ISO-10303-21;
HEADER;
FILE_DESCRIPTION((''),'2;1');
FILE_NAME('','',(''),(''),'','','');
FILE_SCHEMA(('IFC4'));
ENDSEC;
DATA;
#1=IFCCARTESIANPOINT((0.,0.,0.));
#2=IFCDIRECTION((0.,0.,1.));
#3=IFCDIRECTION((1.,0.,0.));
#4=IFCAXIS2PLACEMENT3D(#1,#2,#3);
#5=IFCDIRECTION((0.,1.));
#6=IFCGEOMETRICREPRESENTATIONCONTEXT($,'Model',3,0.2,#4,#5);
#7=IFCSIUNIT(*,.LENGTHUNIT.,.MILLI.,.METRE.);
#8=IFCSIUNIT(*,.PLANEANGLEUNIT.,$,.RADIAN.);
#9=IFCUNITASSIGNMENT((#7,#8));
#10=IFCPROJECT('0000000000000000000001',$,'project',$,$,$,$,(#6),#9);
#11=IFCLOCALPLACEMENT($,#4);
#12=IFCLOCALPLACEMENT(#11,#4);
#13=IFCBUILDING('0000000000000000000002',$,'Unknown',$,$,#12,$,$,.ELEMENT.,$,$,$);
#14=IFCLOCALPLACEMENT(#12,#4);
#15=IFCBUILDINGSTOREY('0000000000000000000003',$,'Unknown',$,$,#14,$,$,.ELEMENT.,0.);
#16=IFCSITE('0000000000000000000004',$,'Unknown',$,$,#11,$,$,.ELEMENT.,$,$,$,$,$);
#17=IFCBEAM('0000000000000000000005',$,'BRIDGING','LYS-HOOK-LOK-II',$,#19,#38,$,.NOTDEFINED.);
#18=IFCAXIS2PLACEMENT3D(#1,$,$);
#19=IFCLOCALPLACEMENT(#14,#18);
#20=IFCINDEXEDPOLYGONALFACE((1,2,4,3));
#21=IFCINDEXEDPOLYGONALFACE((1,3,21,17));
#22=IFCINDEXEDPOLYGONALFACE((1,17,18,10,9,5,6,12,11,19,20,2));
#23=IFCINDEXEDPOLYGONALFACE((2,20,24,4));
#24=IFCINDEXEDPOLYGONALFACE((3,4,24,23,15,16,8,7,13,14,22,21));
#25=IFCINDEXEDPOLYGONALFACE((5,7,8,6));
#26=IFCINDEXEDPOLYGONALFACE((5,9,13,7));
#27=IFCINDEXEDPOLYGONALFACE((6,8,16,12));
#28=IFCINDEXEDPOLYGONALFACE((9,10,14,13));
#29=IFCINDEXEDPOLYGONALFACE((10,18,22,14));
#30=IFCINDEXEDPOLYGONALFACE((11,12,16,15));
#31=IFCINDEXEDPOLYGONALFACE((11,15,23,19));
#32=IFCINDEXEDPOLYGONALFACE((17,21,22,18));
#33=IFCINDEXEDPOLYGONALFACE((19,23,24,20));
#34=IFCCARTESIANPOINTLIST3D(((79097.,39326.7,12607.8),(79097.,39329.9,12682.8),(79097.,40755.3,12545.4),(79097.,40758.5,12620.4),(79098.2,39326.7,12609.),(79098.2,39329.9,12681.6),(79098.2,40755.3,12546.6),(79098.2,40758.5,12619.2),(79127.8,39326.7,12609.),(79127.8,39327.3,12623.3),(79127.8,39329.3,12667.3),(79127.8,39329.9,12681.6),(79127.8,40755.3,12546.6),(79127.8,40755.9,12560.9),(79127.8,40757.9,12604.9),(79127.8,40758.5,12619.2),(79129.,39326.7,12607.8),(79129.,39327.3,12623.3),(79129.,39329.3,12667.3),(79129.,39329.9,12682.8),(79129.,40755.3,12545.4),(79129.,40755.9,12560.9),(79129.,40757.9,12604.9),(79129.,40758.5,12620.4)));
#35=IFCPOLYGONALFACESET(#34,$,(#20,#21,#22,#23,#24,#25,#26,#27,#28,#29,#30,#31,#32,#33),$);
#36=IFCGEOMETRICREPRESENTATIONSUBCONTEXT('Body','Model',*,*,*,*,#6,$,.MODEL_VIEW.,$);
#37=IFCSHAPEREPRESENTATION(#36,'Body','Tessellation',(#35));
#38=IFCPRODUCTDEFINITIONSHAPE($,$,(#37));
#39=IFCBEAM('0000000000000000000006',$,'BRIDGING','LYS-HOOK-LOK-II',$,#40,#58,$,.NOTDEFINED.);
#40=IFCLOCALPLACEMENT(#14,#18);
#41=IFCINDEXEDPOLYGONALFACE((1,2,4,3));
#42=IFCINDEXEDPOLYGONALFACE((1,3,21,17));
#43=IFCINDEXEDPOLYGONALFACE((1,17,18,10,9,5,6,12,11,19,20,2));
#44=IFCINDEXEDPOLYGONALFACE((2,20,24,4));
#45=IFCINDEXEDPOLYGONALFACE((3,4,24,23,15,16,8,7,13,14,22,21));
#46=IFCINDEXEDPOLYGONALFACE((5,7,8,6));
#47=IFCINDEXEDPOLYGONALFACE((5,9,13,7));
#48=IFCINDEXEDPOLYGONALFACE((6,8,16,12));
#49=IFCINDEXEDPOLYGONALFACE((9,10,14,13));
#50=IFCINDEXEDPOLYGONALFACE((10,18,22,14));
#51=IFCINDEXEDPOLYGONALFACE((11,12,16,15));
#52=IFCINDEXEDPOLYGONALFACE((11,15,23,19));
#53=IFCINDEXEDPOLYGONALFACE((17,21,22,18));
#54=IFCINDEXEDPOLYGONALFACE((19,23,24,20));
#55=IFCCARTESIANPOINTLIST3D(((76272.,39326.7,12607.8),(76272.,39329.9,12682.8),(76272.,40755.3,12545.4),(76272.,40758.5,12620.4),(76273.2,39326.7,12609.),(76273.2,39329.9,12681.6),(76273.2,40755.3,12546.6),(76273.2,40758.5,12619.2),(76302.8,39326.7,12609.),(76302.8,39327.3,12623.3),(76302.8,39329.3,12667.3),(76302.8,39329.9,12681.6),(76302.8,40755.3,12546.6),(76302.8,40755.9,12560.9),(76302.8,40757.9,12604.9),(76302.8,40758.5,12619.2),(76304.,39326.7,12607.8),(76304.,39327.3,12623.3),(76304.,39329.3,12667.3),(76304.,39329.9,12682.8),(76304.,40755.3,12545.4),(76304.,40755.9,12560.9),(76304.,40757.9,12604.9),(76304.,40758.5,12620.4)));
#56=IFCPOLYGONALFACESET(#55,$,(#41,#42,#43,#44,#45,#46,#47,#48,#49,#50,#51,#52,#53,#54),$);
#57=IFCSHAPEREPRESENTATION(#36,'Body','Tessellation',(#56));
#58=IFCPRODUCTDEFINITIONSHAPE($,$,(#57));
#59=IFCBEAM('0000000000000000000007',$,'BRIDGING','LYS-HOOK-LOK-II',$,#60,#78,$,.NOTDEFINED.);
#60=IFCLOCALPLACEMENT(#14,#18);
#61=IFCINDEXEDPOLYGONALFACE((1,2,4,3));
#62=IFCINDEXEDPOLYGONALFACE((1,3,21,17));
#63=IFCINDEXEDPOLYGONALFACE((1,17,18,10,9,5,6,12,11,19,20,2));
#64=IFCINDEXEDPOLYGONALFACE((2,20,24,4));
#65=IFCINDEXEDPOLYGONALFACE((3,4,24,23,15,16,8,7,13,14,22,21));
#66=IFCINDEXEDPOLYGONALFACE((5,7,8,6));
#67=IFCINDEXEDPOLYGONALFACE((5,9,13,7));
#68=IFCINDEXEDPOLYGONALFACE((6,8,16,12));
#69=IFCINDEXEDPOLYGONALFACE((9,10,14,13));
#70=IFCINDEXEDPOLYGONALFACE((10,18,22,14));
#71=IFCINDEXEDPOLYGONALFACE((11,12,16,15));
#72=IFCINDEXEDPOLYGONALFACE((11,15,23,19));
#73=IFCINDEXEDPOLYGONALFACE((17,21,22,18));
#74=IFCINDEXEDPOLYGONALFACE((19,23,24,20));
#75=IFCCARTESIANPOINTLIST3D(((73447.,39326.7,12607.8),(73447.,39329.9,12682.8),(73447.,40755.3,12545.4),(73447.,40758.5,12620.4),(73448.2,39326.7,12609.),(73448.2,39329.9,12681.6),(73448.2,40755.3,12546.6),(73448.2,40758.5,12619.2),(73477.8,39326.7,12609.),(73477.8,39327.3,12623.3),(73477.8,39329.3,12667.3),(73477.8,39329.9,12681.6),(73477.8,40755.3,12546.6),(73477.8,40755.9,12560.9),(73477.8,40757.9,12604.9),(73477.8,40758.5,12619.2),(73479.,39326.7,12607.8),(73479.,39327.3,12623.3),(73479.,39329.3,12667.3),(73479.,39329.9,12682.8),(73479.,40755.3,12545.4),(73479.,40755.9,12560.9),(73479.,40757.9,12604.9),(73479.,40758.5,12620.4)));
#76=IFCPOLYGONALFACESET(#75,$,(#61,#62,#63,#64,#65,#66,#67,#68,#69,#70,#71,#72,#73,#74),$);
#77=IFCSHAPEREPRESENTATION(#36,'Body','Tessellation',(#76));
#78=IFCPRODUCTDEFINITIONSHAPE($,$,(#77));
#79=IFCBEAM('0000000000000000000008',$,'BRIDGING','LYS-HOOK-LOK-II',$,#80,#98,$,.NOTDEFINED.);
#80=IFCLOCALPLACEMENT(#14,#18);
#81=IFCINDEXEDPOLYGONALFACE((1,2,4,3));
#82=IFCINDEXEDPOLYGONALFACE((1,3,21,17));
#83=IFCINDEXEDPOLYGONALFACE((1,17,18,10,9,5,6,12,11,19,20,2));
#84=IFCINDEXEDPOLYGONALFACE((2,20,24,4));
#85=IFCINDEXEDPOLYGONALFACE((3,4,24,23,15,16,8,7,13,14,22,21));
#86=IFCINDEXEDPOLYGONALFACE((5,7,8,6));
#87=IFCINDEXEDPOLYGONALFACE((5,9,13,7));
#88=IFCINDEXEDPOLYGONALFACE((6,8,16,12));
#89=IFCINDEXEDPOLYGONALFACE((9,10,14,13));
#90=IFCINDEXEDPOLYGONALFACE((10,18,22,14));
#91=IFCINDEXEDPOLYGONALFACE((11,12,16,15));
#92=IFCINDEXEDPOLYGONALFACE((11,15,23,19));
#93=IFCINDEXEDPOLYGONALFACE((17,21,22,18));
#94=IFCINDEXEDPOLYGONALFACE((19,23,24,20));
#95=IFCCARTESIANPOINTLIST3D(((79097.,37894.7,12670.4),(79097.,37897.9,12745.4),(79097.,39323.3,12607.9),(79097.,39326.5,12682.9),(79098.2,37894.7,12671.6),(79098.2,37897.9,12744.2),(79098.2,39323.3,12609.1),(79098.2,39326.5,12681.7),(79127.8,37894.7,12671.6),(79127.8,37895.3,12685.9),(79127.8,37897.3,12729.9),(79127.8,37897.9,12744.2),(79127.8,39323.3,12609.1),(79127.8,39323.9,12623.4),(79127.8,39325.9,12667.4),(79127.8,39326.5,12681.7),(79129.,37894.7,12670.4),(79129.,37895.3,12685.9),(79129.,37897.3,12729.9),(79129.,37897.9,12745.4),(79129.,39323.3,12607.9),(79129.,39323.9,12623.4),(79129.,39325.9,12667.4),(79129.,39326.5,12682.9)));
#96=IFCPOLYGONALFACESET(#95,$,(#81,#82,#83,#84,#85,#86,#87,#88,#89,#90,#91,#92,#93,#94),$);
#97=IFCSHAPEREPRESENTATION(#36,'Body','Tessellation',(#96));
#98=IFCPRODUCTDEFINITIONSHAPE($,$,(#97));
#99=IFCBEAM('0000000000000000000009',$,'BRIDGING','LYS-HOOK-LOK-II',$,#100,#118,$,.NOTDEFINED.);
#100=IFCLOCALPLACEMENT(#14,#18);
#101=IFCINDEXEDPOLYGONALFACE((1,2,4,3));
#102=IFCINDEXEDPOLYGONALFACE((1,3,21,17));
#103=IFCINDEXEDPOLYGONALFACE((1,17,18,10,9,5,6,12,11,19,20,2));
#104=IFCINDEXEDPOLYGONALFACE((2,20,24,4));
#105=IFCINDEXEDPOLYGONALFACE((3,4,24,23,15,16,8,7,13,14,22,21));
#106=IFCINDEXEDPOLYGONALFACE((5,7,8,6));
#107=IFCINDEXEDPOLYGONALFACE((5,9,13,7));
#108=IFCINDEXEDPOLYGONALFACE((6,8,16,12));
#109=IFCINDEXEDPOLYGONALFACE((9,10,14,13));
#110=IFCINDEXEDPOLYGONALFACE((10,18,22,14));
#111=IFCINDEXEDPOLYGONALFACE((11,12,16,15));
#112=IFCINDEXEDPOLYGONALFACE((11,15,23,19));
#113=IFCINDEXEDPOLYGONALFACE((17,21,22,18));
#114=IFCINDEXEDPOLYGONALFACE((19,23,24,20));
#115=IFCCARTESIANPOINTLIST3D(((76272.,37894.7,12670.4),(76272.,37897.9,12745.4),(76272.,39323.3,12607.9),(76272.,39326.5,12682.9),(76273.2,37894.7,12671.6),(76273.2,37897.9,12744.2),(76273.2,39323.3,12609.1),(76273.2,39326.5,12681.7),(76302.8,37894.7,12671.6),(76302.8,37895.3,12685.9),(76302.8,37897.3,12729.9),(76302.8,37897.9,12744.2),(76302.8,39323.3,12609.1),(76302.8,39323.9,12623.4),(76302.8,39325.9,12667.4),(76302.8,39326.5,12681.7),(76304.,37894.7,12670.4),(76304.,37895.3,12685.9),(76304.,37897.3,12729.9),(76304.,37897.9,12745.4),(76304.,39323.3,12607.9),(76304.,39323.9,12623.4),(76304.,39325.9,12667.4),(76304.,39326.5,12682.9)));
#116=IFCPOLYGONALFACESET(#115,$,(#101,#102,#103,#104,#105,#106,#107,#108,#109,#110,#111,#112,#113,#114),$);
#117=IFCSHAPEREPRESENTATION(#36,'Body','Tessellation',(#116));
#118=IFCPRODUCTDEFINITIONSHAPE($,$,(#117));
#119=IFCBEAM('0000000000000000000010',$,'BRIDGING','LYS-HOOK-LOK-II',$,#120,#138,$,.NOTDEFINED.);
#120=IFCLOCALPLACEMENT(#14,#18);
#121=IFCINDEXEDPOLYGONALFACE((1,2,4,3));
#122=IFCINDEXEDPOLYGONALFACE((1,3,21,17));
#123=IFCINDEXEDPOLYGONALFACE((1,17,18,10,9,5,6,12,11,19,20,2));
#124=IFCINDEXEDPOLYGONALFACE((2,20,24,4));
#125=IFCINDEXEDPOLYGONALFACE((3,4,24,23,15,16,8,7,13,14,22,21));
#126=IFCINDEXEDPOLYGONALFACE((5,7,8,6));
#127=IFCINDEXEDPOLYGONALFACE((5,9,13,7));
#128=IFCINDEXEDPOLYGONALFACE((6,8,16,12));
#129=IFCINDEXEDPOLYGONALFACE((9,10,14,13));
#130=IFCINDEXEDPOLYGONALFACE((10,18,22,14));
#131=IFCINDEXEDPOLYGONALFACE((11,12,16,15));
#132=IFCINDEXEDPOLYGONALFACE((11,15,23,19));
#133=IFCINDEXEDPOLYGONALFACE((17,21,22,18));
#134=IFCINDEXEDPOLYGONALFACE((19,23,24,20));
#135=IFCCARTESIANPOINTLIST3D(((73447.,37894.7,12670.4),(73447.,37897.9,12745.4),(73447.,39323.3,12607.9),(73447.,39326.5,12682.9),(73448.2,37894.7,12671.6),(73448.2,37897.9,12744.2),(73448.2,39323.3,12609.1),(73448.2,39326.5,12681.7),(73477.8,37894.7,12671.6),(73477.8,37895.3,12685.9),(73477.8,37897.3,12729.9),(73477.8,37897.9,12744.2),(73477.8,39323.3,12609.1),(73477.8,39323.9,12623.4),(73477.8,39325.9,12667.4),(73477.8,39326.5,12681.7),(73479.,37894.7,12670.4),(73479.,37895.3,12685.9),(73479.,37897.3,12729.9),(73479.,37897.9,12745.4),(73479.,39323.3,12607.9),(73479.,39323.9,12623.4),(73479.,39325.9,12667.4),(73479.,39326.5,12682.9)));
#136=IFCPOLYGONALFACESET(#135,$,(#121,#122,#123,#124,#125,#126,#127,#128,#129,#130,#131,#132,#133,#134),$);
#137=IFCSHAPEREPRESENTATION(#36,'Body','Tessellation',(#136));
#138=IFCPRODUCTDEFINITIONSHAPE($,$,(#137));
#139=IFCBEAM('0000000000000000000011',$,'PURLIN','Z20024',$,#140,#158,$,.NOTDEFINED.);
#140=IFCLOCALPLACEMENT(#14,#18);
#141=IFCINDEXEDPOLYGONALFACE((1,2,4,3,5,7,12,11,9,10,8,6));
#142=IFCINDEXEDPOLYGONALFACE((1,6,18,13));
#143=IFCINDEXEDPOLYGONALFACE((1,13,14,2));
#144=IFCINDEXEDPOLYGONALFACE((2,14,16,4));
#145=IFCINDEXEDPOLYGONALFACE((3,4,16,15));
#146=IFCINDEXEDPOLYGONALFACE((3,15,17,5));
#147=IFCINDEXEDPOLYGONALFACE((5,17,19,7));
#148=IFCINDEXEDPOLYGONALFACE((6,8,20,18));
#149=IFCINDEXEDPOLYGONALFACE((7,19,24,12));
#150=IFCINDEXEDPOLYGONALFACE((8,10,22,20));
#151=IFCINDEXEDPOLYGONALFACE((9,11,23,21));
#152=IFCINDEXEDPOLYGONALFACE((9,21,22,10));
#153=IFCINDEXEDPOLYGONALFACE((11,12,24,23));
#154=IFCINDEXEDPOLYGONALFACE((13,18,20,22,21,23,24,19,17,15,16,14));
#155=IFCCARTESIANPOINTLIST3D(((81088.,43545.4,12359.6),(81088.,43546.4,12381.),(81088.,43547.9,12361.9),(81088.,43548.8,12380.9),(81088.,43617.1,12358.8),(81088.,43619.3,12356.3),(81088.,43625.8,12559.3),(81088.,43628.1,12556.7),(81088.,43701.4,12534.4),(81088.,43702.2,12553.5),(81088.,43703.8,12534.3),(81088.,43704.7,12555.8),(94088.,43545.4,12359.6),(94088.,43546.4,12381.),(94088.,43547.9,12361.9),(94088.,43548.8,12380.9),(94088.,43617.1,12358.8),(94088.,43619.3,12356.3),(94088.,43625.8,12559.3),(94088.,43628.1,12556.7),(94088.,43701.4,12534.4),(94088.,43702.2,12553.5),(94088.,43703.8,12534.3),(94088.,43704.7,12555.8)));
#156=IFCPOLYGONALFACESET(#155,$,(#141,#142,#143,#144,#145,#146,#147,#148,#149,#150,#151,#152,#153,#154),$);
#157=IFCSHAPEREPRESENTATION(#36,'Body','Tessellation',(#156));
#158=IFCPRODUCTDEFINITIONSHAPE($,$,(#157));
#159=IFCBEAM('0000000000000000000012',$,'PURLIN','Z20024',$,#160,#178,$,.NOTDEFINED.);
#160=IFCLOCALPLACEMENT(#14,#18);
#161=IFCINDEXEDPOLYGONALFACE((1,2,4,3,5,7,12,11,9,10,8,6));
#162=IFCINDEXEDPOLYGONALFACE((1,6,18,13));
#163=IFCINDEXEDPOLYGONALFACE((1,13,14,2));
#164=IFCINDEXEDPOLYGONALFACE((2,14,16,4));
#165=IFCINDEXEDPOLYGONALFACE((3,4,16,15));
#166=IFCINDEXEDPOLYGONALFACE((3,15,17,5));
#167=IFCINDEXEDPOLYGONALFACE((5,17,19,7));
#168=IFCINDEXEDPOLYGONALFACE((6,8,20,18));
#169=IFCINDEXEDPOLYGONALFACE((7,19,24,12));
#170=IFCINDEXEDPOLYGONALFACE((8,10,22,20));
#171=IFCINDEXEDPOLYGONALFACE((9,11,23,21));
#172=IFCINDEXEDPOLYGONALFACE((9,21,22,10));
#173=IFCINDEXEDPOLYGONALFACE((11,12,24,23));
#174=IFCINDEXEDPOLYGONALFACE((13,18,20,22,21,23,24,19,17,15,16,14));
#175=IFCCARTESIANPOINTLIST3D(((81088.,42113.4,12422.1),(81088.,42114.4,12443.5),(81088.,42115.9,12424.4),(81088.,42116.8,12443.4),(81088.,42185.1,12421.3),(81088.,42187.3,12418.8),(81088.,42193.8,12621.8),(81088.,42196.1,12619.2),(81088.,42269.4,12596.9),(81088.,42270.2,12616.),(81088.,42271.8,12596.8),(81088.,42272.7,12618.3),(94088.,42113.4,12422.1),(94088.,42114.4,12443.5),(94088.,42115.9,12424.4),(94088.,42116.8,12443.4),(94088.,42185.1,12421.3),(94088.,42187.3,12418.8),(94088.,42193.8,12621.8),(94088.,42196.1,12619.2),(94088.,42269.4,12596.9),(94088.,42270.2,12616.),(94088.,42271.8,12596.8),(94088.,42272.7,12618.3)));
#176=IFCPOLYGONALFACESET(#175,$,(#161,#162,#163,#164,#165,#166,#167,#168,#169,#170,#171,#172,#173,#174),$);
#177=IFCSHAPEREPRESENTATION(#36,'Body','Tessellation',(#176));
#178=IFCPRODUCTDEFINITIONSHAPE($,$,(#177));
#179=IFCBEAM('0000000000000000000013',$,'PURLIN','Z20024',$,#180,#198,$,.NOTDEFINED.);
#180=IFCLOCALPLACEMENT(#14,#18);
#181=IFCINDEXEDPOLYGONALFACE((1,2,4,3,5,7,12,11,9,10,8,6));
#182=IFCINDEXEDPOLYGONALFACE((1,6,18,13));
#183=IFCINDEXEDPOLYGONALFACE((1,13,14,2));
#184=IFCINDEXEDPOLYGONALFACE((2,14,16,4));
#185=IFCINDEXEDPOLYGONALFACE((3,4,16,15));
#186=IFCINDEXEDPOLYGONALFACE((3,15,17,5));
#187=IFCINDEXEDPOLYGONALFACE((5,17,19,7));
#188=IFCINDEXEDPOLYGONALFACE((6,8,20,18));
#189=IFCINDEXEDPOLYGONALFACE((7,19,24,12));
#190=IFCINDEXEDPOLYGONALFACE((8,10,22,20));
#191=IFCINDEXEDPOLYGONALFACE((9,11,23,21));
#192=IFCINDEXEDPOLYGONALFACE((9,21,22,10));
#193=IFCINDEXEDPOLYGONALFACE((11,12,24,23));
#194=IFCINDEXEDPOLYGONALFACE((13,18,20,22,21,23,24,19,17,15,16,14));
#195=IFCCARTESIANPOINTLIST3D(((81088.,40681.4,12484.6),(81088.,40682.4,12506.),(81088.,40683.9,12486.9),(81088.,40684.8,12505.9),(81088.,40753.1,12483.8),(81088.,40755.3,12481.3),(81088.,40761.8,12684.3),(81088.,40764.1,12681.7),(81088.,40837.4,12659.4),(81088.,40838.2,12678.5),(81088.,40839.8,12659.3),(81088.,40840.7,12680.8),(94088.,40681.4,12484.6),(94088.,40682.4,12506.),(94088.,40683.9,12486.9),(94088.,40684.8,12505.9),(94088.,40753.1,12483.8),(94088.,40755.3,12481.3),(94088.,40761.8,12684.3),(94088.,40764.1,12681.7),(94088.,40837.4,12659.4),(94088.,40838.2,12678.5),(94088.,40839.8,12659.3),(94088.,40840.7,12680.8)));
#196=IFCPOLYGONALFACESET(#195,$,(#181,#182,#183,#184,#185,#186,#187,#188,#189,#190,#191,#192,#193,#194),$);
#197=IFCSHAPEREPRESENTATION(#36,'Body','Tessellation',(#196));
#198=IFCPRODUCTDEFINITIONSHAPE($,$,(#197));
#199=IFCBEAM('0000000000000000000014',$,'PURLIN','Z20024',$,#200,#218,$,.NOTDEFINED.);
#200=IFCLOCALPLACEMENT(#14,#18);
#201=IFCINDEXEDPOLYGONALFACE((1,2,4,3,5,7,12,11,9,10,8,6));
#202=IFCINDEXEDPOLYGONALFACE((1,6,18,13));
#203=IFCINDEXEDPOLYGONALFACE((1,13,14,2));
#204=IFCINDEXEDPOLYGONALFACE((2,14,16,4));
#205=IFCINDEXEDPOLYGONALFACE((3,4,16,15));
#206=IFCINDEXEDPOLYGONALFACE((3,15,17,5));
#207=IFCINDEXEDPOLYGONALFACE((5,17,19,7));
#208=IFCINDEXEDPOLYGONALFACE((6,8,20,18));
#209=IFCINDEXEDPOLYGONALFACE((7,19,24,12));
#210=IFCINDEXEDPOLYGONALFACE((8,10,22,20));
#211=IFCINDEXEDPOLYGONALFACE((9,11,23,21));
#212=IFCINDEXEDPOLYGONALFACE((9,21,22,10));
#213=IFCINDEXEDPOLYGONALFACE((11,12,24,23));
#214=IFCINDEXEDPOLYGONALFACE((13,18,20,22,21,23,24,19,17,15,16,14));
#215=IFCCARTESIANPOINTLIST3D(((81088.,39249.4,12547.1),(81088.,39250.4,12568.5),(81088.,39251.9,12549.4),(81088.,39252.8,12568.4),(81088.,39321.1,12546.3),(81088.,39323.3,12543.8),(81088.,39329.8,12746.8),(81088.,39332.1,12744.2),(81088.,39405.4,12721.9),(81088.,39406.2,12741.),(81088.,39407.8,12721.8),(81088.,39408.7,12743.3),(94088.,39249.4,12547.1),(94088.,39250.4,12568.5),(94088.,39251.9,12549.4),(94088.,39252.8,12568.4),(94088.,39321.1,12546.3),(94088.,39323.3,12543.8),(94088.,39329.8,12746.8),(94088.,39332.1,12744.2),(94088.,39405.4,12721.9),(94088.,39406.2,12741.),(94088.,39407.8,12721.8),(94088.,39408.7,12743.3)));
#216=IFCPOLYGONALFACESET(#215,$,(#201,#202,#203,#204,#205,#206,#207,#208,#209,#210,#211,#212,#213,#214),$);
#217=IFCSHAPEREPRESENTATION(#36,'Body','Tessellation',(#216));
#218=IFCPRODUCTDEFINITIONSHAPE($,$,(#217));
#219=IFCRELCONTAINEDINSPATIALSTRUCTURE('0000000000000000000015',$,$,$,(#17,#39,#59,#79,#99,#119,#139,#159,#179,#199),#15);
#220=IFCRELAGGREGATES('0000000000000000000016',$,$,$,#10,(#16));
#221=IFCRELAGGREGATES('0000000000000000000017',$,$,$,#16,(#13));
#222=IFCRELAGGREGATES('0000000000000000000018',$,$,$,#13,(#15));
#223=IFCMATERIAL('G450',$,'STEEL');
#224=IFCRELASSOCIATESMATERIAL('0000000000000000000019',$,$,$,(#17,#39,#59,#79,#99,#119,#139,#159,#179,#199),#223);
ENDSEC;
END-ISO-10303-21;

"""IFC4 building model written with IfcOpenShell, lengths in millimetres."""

from ifc_helpers import new_model, si_unit, direction, frame, origin_with_axes, place, context, subcontext, project, spatial, line, indexed_curve, outline, extrude, material, element, save


model = new_model("IFC4")

# Units and contexts
model_context = context("Model", 3, precision=0.2, world=origin_with_axes(), true_north=direction((0.0, 1.0)))
body_context = subcontext(model_context, "Body", "Model", "MODEL_VIEW")
ifc_project = project(units=[si_unit("LENGTHUNIT", "METRE", prefix="MILLI"), si_unit("PLANEANGLEUNIT", "RADIAN")], contexts=[model_context])

# Site, building, storey
site_placement = place(None, origin_with_axes())
site = spatial("IfcSite", under=ifc_project, at=site_placement, Name="Unknown", CompositionType="ELEMENT")
building_placement = place(site_placement, origin_with_axes())
building = spatial("IfcBuilding", under=site, at=building_placement, Name="Unknown", CompositionType="ELEMENT")
storey_placement = place(building_placement, origin_with_axes())
storey = spatial("IfcBuildingStorey", under=building, at=storey_placement, Name="Unknown", CompositionType="ELEMENT", Elevation=0.0)

# Beams
ifc_material_1 = material(Name="G450", Category="STEEL")
for number, where, z_axis, x_axis, name in (
    (1, (79113.0, 39328.3, 12645.3), (1.0, 0.0, 0.0), (0.0, 0.999047, -0.043638), "BRIDGING"),
    (2, (76288.0, 39328.3, 12645.3), (1.0, 0.0, 0.0), (0.0, 0.999047, -0.043638), "BRIDGING"),
    (3, (73463.0, 39328.3, 12645.3), (1.0, 0.0, 0.0), (0.0, 0.999047, -0.043638), "BRIDGING"),
):
    element("IfcBeam", number, at=place(storey_placement, frame(where, z_axis=z_axis, x_axis=x_axis)), inside=storey, material=ifc_material_1, Name=name, Description="LYS-HOOK-LOK-II", PredefinedType="NOTDEFINED", context=body_context, shape_type="SolidModel", body=[
        extrude(outline(indexed_curve([(16.0, -37.5), (16.0, -22.0), (14.8, -22.0), (14.8, -36.3), (-14.8, -36.3), (-14.8, 36.3), (14.8, 36.3), (14.8, 22.0), (16.0, 22.0), (16.0, 37.5), (-16.0, 37.5), (-16.0, -37.5)], segments=[line(1, 2, 3, 4, 5, 6, 7, 8, 9, 10, 11, 12, 1)])), frame((0.0, 0.0, 0.0), z_axis=(-1.0, 0.0, 0.0), x_axis=(0.0, 0.0, 1.0)), (0.0, 0.0, -1.0), 1430.0),
    ])
for number, where, z_axis, x_axis, name in (
    (4, (79113.0, 37896.3, 12707.9), (1.0, 0.0, 0.0), (0.0, 0.999044, -0.043707), "BRIDGING"),
    (5, (76288.0, 37896.3, 12707.9), (1.0, 0.0, 0.0), (0.0, 0.999044, -0.043707), "BRIDGING"),
    (6, (73463.0, 37896.3, 12707.9), (1.0, 0.0, 0.0), (0.0, 0.999044, -0.043707), "BRIDGING"),
):
    element("IfcBeam", number, at=place(storey_placement, frame(where, z_axis=z_axis, x_axis=x_axis)), inside=storey, material=ifc_material_1, Name=name, Description="LYS-HOOK-LOK-II", PredefinedType="NOTDEFINED", context=body_context, shape_type="SolidModel", body=[
        extrude(outline(indexed_curve([(16.0, -37.5), (16.0, -22.0), (14.8, -22.0), (14.8, -36.3), (-14.8, -36.3), (-14.8, 36.3), (14.8, 36.3), (14.8, 22.0), (16.0, 22.0), (16.0, 37.5), (-16.0, 37.5), (-16.0, -37.5)], segments=[line(1, 2, 3, 4, 5, 6, 7, 8, 9, 10, 11, 12, 1)])), frame((0.0, 0.0, 0.0), z_axis=(-1.0, 0.0, 0.0), x_axis=(0.0, 0.0, 1.0)), (0.0, 0.0, -1.0), 1430.0),
    ])
for number, where, z_axis, x_axis, name in (
    (7, (81088.0, 43622.6, 12457.8), (0.0, -0.999048, 0.043619), (1.0, 0.0, 0.0), "PURLIN"),
    (8, (81088.0, 42190.6, 12520.3), (0.0, -0.999048, 0.043619), (1.0, 0.0, 0.0), "PURLIN"),
    (9, (81088.0, 40758.6, 12582.8), (0.0, -0.999048, 0.043619), (1.0, 0.0, 0.0), "PURLIN"),
    (10, (81088.0, 39326.6, 12645.3), (0.0, -0.999048, 0.043619), (1.0, 0.0, 0.0), "PURLIN"),
):
    element("IfcBeam", number, at=place(storey_placement, frame(where, z_axis=z_axis, x_axis=x_axis)), inside=storey, material=ifc_material_1, Name=name, Description="Z20024", PredefinedType="NOTDEFINED", context=body_context, shape_type="SolidModel", body=[
        extrude(outline(indexed_curve([(72.8, -101.5), (72.8, -80.0), (70.4, -80.0), (70.4, -99.1), (1.2, -99.1), (1.2, 101.5), (-77.8, 101.5), (-77.8, 80.0), (-75.4, 80.0), (-75.4, 99.1), (-1.2, 99.1), (-1.2, -101.5)], segments=[line(1, 2, 3, 4, 5, 6, 7, 8, 9, 10, 11, 12, 1)])), frame((0.0, 0.0, 0.0), z_axis=(-1.0, 0.0, 0.0), x_axis=(0.0, 0.0, 1.0)), (0.0, 0.0, -1.0), 13000.0),
    ])

save(model, "model.ifc")
